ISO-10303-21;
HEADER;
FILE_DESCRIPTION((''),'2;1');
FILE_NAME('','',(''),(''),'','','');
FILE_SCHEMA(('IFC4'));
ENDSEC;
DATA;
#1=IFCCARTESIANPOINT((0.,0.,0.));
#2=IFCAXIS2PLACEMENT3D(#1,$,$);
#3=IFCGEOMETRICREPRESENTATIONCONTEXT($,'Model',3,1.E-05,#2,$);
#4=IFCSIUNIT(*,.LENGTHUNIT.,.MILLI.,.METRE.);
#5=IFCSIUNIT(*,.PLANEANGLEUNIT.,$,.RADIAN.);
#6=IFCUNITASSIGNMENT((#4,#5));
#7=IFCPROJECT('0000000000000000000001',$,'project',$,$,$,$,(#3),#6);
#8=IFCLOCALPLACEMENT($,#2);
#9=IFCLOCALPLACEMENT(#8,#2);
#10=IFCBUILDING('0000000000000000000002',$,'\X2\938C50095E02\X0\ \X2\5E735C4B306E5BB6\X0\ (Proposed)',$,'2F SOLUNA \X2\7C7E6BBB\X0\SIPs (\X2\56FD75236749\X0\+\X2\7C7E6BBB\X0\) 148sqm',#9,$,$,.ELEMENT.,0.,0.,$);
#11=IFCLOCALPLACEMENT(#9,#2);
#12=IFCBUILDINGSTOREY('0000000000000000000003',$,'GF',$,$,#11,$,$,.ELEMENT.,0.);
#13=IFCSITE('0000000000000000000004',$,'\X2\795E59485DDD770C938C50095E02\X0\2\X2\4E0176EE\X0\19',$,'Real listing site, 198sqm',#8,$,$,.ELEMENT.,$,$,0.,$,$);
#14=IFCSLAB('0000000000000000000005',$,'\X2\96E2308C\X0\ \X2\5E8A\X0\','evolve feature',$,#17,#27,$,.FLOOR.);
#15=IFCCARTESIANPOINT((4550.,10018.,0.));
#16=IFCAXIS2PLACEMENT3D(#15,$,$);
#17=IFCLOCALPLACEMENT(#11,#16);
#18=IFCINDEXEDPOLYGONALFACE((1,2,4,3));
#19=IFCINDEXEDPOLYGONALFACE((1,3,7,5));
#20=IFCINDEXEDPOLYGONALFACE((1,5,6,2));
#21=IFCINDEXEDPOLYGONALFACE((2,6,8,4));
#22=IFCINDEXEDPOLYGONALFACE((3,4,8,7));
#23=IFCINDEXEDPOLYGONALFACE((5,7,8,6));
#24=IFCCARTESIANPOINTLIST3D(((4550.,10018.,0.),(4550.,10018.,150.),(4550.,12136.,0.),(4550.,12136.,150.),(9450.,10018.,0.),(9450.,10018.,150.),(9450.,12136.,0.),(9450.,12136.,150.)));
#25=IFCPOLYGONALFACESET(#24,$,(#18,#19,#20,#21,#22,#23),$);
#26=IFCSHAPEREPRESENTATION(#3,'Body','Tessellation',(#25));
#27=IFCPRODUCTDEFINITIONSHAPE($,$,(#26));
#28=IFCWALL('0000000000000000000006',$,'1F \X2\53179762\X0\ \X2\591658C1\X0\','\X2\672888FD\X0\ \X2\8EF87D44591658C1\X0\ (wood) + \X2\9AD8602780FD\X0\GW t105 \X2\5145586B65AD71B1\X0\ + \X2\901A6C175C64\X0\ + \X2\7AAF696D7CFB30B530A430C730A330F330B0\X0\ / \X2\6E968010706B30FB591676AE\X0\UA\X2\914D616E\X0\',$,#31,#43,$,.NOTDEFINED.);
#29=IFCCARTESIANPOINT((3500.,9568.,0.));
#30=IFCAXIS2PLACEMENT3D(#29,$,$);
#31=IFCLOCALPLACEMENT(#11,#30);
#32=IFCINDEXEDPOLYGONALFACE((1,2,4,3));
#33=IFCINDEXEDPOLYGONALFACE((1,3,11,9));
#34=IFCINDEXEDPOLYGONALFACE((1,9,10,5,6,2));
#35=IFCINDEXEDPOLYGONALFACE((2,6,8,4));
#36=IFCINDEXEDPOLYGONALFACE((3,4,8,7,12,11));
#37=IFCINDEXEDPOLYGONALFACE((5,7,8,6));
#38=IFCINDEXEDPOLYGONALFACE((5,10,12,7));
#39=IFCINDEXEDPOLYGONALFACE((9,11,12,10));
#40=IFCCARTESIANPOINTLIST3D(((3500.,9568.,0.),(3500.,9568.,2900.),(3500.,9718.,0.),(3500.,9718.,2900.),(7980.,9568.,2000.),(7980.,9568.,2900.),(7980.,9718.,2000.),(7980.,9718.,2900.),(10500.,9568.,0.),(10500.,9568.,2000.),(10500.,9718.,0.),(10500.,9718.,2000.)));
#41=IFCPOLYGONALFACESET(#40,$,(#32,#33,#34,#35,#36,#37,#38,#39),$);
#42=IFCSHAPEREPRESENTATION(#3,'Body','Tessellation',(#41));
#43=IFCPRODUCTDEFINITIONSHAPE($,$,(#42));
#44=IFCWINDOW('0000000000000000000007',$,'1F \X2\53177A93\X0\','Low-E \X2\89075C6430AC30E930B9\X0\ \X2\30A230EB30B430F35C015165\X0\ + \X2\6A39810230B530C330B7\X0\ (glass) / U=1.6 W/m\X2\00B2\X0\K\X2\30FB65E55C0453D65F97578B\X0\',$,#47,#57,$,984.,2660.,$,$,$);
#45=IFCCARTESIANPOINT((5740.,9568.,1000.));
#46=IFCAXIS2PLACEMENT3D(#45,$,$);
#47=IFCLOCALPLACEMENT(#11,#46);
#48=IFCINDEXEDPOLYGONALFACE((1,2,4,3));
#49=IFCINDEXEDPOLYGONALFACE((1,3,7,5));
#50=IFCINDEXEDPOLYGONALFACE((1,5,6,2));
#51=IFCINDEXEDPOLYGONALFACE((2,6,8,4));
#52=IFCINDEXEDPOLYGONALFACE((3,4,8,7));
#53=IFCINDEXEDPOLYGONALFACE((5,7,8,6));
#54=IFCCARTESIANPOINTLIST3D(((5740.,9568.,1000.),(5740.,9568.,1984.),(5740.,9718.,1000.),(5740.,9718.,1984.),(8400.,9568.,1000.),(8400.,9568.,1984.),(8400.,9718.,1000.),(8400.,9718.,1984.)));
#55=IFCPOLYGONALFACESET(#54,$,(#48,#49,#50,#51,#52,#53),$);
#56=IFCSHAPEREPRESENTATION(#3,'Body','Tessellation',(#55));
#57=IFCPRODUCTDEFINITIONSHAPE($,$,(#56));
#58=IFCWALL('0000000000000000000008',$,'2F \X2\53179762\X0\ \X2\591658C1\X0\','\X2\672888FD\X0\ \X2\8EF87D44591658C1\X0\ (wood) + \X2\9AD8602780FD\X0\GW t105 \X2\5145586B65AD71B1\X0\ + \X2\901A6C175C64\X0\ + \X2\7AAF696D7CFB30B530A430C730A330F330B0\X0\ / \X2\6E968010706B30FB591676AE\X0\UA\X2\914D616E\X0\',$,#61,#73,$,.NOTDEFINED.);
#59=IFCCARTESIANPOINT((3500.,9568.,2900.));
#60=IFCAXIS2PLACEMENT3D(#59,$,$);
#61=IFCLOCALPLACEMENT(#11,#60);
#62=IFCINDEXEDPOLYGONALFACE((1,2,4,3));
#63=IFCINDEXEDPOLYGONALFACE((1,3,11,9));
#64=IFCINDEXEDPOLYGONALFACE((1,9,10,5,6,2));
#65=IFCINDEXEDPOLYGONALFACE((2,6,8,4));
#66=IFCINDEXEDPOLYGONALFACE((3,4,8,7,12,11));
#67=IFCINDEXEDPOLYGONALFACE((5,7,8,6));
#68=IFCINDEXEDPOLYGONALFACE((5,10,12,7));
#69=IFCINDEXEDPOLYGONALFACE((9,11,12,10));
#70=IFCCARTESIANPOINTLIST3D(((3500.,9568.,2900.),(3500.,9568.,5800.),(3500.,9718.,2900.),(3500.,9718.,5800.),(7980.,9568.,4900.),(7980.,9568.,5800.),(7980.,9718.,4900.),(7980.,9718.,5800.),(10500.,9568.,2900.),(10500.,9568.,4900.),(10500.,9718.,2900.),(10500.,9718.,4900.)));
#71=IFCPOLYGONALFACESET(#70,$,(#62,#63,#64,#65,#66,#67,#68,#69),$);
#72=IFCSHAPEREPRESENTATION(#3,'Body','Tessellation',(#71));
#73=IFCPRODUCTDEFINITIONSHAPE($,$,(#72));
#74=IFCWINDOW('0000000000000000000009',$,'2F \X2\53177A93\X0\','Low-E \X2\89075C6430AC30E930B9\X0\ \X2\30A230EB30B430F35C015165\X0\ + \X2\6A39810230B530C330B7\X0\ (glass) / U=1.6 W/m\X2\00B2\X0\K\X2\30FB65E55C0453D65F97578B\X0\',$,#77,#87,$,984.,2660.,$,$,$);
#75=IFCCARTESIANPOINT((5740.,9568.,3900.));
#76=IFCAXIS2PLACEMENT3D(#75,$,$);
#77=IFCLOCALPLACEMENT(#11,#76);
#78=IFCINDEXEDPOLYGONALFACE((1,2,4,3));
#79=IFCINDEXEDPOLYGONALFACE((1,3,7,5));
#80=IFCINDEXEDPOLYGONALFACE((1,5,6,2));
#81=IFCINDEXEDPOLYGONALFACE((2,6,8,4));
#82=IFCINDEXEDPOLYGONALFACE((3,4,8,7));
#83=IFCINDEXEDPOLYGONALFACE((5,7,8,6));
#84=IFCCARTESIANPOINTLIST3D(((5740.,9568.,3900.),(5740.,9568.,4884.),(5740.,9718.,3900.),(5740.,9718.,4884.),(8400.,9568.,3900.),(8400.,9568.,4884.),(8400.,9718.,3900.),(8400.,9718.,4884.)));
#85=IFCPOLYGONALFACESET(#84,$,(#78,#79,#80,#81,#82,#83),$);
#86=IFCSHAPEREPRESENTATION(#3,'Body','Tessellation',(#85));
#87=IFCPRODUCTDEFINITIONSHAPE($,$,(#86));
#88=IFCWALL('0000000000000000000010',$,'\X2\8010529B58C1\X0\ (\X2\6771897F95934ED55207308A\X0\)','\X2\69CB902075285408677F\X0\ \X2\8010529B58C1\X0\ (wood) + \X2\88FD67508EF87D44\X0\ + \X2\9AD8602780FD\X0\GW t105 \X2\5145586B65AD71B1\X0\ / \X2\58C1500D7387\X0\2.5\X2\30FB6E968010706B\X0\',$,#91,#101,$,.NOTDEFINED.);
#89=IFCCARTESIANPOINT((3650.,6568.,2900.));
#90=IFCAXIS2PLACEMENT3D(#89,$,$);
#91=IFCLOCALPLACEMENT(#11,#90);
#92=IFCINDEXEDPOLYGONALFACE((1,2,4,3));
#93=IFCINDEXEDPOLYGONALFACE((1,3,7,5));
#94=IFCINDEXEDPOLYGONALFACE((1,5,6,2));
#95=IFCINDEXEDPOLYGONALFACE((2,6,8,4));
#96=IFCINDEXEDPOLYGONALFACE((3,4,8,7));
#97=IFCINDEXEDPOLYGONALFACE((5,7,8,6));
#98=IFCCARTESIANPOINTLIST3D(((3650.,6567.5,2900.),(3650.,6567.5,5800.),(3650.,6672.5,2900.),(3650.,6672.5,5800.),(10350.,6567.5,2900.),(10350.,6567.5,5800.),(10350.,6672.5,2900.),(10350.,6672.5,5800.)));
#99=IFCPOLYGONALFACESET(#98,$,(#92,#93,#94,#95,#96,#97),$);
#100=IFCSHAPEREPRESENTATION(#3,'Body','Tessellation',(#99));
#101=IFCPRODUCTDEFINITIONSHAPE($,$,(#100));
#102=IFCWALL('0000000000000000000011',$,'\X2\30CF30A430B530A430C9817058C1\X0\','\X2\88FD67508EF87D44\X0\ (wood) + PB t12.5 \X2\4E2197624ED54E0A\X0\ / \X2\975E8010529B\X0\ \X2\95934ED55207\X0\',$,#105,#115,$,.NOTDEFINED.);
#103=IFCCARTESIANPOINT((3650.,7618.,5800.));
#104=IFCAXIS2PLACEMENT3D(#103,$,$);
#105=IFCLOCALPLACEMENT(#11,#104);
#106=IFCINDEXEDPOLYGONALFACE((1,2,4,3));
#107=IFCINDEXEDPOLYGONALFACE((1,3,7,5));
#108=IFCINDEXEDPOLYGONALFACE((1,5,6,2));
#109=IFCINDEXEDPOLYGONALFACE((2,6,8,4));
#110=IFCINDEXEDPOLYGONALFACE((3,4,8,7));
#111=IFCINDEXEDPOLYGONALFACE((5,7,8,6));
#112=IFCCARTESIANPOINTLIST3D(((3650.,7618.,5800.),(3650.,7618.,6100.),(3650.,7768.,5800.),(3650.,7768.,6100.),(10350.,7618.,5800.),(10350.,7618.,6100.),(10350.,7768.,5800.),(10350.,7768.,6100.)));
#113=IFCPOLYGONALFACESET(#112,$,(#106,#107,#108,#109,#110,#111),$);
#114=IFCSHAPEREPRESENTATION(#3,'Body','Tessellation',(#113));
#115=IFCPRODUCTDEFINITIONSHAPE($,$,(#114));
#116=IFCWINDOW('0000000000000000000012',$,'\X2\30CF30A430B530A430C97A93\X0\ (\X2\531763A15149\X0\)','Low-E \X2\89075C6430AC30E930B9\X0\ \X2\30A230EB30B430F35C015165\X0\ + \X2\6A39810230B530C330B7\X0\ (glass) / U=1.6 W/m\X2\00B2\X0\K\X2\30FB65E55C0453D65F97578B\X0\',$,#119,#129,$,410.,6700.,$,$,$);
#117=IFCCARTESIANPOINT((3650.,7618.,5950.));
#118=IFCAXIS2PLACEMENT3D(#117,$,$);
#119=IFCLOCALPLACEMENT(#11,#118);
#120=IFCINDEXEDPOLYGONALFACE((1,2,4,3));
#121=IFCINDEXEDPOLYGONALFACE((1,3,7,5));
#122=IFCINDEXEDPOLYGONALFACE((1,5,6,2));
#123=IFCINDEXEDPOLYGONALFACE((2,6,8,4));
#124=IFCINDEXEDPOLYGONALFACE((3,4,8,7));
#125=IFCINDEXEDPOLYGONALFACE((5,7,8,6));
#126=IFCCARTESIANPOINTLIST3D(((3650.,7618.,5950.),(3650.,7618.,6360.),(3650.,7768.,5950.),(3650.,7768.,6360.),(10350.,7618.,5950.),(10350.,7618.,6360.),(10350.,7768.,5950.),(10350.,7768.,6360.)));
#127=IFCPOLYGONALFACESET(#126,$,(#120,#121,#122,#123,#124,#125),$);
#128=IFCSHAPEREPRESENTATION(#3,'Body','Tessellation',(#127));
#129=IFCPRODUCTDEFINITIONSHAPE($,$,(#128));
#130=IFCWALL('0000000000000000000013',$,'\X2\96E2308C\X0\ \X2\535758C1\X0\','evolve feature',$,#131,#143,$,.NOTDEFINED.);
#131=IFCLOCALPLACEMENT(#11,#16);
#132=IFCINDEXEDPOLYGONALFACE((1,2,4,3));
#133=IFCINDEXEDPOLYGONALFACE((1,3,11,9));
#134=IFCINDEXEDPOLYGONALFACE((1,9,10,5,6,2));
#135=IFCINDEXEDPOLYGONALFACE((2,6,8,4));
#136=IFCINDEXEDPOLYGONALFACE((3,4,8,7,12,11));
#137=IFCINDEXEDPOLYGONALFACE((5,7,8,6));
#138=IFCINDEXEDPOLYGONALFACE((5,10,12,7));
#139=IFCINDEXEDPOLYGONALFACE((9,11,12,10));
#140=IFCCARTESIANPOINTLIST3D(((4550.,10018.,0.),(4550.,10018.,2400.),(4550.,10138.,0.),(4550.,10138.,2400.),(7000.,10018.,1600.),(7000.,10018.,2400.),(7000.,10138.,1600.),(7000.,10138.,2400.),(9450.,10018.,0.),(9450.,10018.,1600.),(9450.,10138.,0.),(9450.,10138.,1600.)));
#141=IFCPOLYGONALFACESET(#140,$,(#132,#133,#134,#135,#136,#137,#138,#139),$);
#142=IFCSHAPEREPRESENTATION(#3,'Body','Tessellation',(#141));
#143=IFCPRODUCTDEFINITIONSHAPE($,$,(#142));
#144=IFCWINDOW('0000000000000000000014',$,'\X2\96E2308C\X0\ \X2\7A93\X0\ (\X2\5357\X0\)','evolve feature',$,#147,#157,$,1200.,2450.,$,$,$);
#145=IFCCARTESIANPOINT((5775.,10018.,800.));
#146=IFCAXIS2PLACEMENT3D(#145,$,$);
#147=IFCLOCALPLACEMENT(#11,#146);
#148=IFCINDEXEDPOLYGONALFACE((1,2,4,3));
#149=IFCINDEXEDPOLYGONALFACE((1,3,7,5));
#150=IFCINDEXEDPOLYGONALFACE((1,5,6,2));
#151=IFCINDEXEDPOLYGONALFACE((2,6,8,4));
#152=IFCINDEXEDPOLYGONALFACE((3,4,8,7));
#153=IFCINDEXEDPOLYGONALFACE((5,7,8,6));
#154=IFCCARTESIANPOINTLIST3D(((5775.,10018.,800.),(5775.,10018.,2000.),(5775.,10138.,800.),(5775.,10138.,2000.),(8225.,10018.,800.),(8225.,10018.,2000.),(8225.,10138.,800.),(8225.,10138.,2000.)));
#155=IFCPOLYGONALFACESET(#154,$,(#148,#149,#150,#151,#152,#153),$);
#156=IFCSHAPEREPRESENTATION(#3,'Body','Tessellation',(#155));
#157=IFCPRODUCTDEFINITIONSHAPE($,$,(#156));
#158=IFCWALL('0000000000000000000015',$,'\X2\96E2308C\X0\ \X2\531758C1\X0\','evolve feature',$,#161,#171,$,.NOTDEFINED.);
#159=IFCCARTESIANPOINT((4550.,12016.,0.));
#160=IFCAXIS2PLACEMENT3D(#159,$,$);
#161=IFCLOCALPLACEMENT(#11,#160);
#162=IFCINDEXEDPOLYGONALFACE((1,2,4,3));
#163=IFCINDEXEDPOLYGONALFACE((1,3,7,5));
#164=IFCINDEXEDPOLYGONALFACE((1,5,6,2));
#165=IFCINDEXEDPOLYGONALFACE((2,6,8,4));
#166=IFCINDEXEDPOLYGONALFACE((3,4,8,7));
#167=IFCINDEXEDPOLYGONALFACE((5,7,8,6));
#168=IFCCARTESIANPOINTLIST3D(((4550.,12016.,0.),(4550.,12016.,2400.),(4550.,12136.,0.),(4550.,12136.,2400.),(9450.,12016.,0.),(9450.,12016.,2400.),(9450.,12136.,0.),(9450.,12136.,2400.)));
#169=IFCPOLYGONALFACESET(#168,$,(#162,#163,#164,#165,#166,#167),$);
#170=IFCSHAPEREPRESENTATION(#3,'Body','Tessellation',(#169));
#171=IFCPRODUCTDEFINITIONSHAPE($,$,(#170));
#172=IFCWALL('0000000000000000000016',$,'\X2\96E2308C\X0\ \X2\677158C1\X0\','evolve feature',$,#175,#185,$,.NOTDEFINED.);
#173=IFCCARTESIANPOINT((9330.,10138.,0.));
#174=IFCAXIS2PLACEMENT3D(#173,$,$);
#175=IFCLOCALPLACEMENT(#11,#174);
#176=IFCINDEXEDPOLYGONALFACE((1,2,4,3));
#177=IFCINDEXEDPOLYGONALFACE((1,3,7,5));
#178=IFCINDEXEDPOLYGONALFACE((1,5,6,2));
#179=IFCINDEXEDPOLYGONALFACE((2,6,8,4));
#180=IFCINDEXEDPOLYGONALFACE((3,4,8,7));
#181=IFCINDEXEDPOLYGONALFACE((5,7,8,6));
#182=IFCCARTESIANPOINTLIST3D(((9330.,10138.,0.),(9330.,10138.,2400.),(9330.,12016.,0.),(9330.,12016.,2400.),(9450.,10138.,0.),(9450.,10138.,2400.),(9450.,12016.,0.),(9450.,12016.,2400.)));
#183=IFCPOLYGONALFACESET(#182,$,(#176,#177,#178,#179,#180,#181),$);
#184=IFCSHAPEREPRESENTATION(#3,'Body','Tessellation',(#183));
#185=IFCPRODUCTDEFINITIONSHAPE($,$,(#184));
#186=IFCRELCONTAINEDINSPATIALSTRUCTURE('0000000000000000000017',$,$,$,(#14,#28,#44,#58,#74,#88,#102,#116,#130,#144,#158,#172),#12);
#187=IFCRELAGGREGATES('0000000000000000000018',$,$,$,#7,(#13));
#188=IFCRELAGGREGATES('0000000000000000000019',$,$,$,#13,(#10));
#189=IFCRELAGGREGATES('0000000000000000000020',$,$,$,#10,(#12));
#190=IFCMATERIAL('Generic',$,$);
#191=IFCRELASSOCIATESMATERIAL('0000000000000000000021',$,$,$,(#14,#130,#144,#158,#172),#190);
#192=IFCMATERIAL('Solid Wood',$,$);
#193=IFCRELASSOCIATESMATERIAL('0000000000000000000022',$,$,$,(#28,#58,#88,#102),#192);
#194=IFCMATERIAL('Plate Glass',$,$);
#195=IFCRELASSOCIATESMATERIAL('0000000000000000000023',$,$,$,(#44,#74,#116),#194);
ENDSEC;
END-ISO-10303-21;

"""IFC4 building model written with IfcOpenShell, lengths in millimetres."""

from ifc_helpers import new_model, si_unit, frame, frame_2d, origin, place, context, project, spatial, rectangle, extrude, material, element, fill, save


model = new_model("IFC4")

# Units and contexts
model_context = context("Model", 3, precision=1e-05, world=origin())
ifc_project = project(units=[si_unit("LENGTHUNIT", "METRE", prefix="MILLI"), si_unit("PLANEANGLEUNIT", "RADIAN")], contexts=[model_context])

# Site, building, storey
site_placement = place(None, origin())
site = spatial("IfcSite", under=ifc_project, at=site_placement, Name="神奈川県鎌倉市2丁目19", ObjectType="Real listing site, 198sqm", CompositionType="ELEMENT", RefElevation=0.0)
building_placement = place(site_placement, origin())
building = spatial("IfcBuilding", under=site, at=building_placement, Name="鎌倉市 平屋の家 (Proposed)", ObjectType="2F SOLUNA 籾殻SIPs (国産杉+籾殻) 148sqm", CompositionType="ELEMENT", ElevationOfRefHeight=0.0, ElevationOfTerrain=0.0)
storey_placement = place(building_placement, origin())
storey = spatial("IfcBuildingStorey", under=building, at=storey_placement, Name="GF", CompositionType="ELEMENT", Elevation=0.0)

# Slab
ifc_material_1 = material(Name="Generic")
slab_placement = place(storey_placement, frame((4550.0, 10018.0, 0.0)))
element("IfcSlab", 1, at=slab_placement, inside=storey, material=ifc_material_1, Name="離れ 床", Description="evolve feature", PredefinedType="FLOOR", context=model_context, shape_type="SweptSolid", body=[
    extrude(rectangle(XDim=4900.0, YDim=2118.0, at=frame_2d((2450.0, 1059.0))), frame((4550.0, 10018.0, 0.0)), (0.0, 0.0, 1.0), 150.0),
])

# Wall, opening, window
ifc_material_2 = material(Name="Solid Wood")
wall_1_placement = place(storey_placement, frame((3500.0, 9568.0, 0.0)))
wall_1 = element("IfcWall", 2, at=wall_1_placement, inside=storey, material=ifc_material_2, Name="1F 北面 外壁", Description="木製 軸組外壁 (wood) + 高性能GW t105 充填断熱 + 通気層 + 窯業系サイディング / 準耐火・外皮UA配慮", PredefinedType="NOTDEFINED", context=model_context, shape_type="SweptSolid", body=[
    extrude(rectangle(XDim=7000.0, YDim=150.0, at=frame_2d((3500.0, 75.0))), frame((3500.0, 9568.0, 0.0)), (0.0, 0.0, 1.0), 2900.0),
])
opening_1_placement = place(storey_placement, frame((5740.0, 9568.0, 1000.0)))
opening_1 = element("IfcOpeningElement", 3, at=opening_1_placement, cuts=wall_1, PredefinedType="NOTDEFINED", context=model_context, shape_type="SweptSolid", body=[
    extrude(rectangle(XDim=2660.0, YDim=150.0, at=frame_2d((1330.0, 75.0))), frame((5740.0, 9568.0, 1000.0)), (0.0, 0.0, 1.0), 984.0),
])
ifc_material_3 = material(Name="Plate Glass")
window_1_placement = place(storey_placement, frame((5740.0, 9568.0, 1000.0)))
window_1 = element("IfcWindow", 4, at=window_1_placement, inside=storey, material=ifc_material_3, Name="1F 北窓", Description="Low-E 複層ガラス アルゴン封入 + 樹脂サッシ (glass) / U=1.6 W/m²K・日射取得型", OverallHeight=984.0, OverallWidth=2660.0, context=model_context, shape_type="SweptSolid", body=[
    extrude(rectangle(XDim=2660.0, YDim=150.0, at=frame_2d((1330.0, 75.0))), frame((5740.0, 9568.0, 1000.0)), (0.0, 0.0, 1.0), 984.0),
])
fill(opening_1, window_1)

# Wall, opening, window
wall_2_placement = place(storey_placement, frame((3500.0, 9568.0, 2900.0)))
wall_2 = element("IfcWall", 5, at=wall_2_placement, inside=storey, material=ifc_material_2, Name="2F 北面 外壁", Description="木製 軸組外壁 (wood) + 高性能GW t105 充填断熱 + 通気層 + 窯業系サイディング / 準耐火・外皮UA配慮", PredefinedType="NOTDEFINED", context=model_context, shape_type="SweptSolid", body=[
    extrude(rectangle(XDim=7000.0, YDim=150.0, at=frame_2d((3500.0, 75.0))), frame((3500.0, 9568.0, 2900.0)), (0.0, 0.0, 1.0), 2900.0),
])
opening_2_placement = place(storey_placement, frame((5740.0, 9568.0, 3900.0)))
opening_2 = element("IfcOpeningElement", 6, at=opening_2_placement, cuts=wall_2, PredefinedType="NOTDEFINED", context=model_context, shape_type="SweptSolid", body=[
    extrude(rectangle(XDim=2660.0, YDim=150.0, at=frame_2d((1330.0, 75.0))), frame((5740.0, 9568.0, 3900.0)), (0.0, 0.0, 1.0), 984.0),
])
window_2_placement = place(storey_placement, frame((5740.0, 9568.0, 3900.0)))
window_2 = element("IfcWindow", 7, at=window_2_placement, inside=storey, material=ifc_material_3, Name="2F 北窓", Description="Low-E 複層ガラス アルゴン封入 + 樹脂サッシ (glass) / U=1.6 W/m²K・日射取得型", OverallHeight=984.0, OverallWidth=2660.0, context=model_context, shape_type="SweptSolid", body=[
    extrude(rectangle(XDim=2660.0, YDim=150.0, at=frame_2d((1330.0, 75.0))), frame((5740.0, 9568.0, 3900.0)), (0.0, 0.0, 1.0), 984.0),
])
fill(opening_2, window_2)

# Wall
wall_3_placement = place(storey_placement, frame((3650.0, 6568.0, 2900.0)))
element("IfcWall", 8, at=wall_3_placement, inside=storey, material=ifc_material_2, Name="耐力壁 (東西間仕切り)", Description="構造用合板 耐力壁 (wood) + 製材軸組 + 高性能GW t105 充填断熱 / 壁倍率2.5・準耐火", PredefinedType="NOTDEFINED", context=model_context, shape_type="SweptSolid", body=[
    extrude(rectangle(XDim=6700.0, YDim=105.0, at=frame_2d((3350.0, 52.0))), frame((3650.0, 6568.0, 2900.0)), (0.0, 0.0, 1.0), 2900.0),
])

# Walls, openings, windows
wall_4_placement = place(storey_placement, frame((3650.0, 7618.0, 5800.0)))
wall_4 = element("IfcWall", 9, at=wall_4_placement, inside=storey, material=ifc_material_2, Name="ハイサイド腰壁", Description="製材軸組 (wood) + PB t12.5 両面仕上 / 非耐力 間仕切", PredefinedType="NOTDEFINED", context=model_context, shape_type="SweptSolid", body=[
    extrude(rectangle(XDim=6700.0, YDim=150.0, at=frame_2d((3350.0, 75.0))), frame((3650.0, 7618.0, 5800.0)), (0.0, 0.0, 1.0), 700.0),
])
opening_3_placement = place(storey_placement, frame((3650.0, 7618.0, 5950.0)))
opening_3 = element("IfcOpeningElement", 10, at=opening_3_placement, cuts=wall_4, PredefinedType="NOTDEFINED", context=model_context, shape_type="SweptSolid", body=[
    extrude(rectangle(XDim=6700.0, YDim=150.0, at=frame_2d((3350.0, 75.0))), frame((3650.0, 7618.0, 5950.0)), (0.0, 0.0, 1.0), 410.0),
])
window_3_placement = place(storey_placement, frame((3650.0, 7618.0, 5950.0)))
window_3 = element("IfcWindow", 11, at=window_3_placement, inside=storey, material=ifc_material_3, Name="ハイサイド窓 (北採光)", Description="Low-E 複層ガラス アルゴン封入 + 樹脂サッシ (glass) / U=1.6 W/m²K・日射取得型", OverallHeight=410.0, OverallWidth=6700.0, context=model_context, shape_type="SweptSolid", body=[
    extrude(rectangle(XDim=6700.0, YDim=150.0, at=frame_2d((3350.0, 75.0))), frame((3650.0, 7618.0, 5950.0)), (0.0, 0.0, 1.0), 410.0),
])
fill(opening_3, window_3)
wall_5_placement = place(storey_placement, frame((4550.0, 10018.0, 0.0)))
wall_5 = element("IfcWall", 12, at=wall_5_placement, inside=storey, material=ifc_material_1, Name="離れ 南壁", Description="evolve feature", PredefinedType="NOTDEFINED", context=model_context, shape_type="SweptSolid", body=[
    extrude(rectangle(XDim=4900.0, YDim=120.0, at=frame_2d((2450.0, 60.0))), frame((4550.0, 10018.0, 0.0)), (0.0, 0.0, 1.0), 2400.0),
])
opening_4_placement = place(storey_placement, frame((5775.0, 10018.0, 800.0)))
opening_4 = element("IfcOpeningElement", 13, at=opening_4_placement, cuts=wall_5, PredefinedType="NOTDEFINED", context=model_context, shape_type="SweptSolid", body=[
    extrude(rectangle(XDim=2450.0, YDim=120.0, at=frame_2d((1225.0, 60.0))), frame((5775.0, 10018.0, 800.0)), (0.0, 0.0, 1.0), 1200.0),
])
window_4_placement = place(storey_placement, frame((5775.0, 10018.0, 800.0)))
window_4 = element("IfcWindow", 14, at=window_4_placement, inside=storey, material=ifc_material_1, Name="離れ 窓 (南)", Description="evolve feature", OverallHeight=1200.0, OverallWidth=2450.0, context=model_context, shape_type="SweptSolid", body=[
    extrude(rectangle(XDim=2450.0, YDim=120.0, at=frame_2d((1225.0, 60.0))), frame((5775.0, 10018.0, 800.0)), (0.0, 0.0, 1.0), 1200.0),
])
fill(opening_4, window_4)

# Walls
wall_6_placement = place(storey_placement, frame((4550.0, 12016.0, 0.0)))
element("IfcWall", 15, at=wall_6_placement, inside=storey, material=ifc_material_1, Name="離れ 北壁", Description="evolve feature", PredefinedType="NOTDEFINED", context=model_context, shape_type="SweptSolid", body=[
    extrude(rectangle(XDim=4900.0, YDim=120.0, at=frame_2d((2450.0, 60.0))), frame((4550.0, 12016.0, 0.0)), (0.0, 0.0, 1.0), 2400.0),
])
wall_7_placement = place(storey_placement, frame((9330.0, 10138.0, 0.0)))
element("IfcWall", 16, at=wall_7_placement, inside=storey, material=ifc_material_1, Name="離れ 東壁", Description="evolve feature", PredefinedType="NOTDEFINED", context=model_context, shape_type="SweptSolid", body=[
    extrude(rectangle(XDim=120.0, YDim=1878.0, at=frame_2d((60.0, 939.0))), frame((9330.0, 10138.0, 0.0)), (0.0, 0.0, 1.0), 2400.0),
])

save(model, "model.ifc")
